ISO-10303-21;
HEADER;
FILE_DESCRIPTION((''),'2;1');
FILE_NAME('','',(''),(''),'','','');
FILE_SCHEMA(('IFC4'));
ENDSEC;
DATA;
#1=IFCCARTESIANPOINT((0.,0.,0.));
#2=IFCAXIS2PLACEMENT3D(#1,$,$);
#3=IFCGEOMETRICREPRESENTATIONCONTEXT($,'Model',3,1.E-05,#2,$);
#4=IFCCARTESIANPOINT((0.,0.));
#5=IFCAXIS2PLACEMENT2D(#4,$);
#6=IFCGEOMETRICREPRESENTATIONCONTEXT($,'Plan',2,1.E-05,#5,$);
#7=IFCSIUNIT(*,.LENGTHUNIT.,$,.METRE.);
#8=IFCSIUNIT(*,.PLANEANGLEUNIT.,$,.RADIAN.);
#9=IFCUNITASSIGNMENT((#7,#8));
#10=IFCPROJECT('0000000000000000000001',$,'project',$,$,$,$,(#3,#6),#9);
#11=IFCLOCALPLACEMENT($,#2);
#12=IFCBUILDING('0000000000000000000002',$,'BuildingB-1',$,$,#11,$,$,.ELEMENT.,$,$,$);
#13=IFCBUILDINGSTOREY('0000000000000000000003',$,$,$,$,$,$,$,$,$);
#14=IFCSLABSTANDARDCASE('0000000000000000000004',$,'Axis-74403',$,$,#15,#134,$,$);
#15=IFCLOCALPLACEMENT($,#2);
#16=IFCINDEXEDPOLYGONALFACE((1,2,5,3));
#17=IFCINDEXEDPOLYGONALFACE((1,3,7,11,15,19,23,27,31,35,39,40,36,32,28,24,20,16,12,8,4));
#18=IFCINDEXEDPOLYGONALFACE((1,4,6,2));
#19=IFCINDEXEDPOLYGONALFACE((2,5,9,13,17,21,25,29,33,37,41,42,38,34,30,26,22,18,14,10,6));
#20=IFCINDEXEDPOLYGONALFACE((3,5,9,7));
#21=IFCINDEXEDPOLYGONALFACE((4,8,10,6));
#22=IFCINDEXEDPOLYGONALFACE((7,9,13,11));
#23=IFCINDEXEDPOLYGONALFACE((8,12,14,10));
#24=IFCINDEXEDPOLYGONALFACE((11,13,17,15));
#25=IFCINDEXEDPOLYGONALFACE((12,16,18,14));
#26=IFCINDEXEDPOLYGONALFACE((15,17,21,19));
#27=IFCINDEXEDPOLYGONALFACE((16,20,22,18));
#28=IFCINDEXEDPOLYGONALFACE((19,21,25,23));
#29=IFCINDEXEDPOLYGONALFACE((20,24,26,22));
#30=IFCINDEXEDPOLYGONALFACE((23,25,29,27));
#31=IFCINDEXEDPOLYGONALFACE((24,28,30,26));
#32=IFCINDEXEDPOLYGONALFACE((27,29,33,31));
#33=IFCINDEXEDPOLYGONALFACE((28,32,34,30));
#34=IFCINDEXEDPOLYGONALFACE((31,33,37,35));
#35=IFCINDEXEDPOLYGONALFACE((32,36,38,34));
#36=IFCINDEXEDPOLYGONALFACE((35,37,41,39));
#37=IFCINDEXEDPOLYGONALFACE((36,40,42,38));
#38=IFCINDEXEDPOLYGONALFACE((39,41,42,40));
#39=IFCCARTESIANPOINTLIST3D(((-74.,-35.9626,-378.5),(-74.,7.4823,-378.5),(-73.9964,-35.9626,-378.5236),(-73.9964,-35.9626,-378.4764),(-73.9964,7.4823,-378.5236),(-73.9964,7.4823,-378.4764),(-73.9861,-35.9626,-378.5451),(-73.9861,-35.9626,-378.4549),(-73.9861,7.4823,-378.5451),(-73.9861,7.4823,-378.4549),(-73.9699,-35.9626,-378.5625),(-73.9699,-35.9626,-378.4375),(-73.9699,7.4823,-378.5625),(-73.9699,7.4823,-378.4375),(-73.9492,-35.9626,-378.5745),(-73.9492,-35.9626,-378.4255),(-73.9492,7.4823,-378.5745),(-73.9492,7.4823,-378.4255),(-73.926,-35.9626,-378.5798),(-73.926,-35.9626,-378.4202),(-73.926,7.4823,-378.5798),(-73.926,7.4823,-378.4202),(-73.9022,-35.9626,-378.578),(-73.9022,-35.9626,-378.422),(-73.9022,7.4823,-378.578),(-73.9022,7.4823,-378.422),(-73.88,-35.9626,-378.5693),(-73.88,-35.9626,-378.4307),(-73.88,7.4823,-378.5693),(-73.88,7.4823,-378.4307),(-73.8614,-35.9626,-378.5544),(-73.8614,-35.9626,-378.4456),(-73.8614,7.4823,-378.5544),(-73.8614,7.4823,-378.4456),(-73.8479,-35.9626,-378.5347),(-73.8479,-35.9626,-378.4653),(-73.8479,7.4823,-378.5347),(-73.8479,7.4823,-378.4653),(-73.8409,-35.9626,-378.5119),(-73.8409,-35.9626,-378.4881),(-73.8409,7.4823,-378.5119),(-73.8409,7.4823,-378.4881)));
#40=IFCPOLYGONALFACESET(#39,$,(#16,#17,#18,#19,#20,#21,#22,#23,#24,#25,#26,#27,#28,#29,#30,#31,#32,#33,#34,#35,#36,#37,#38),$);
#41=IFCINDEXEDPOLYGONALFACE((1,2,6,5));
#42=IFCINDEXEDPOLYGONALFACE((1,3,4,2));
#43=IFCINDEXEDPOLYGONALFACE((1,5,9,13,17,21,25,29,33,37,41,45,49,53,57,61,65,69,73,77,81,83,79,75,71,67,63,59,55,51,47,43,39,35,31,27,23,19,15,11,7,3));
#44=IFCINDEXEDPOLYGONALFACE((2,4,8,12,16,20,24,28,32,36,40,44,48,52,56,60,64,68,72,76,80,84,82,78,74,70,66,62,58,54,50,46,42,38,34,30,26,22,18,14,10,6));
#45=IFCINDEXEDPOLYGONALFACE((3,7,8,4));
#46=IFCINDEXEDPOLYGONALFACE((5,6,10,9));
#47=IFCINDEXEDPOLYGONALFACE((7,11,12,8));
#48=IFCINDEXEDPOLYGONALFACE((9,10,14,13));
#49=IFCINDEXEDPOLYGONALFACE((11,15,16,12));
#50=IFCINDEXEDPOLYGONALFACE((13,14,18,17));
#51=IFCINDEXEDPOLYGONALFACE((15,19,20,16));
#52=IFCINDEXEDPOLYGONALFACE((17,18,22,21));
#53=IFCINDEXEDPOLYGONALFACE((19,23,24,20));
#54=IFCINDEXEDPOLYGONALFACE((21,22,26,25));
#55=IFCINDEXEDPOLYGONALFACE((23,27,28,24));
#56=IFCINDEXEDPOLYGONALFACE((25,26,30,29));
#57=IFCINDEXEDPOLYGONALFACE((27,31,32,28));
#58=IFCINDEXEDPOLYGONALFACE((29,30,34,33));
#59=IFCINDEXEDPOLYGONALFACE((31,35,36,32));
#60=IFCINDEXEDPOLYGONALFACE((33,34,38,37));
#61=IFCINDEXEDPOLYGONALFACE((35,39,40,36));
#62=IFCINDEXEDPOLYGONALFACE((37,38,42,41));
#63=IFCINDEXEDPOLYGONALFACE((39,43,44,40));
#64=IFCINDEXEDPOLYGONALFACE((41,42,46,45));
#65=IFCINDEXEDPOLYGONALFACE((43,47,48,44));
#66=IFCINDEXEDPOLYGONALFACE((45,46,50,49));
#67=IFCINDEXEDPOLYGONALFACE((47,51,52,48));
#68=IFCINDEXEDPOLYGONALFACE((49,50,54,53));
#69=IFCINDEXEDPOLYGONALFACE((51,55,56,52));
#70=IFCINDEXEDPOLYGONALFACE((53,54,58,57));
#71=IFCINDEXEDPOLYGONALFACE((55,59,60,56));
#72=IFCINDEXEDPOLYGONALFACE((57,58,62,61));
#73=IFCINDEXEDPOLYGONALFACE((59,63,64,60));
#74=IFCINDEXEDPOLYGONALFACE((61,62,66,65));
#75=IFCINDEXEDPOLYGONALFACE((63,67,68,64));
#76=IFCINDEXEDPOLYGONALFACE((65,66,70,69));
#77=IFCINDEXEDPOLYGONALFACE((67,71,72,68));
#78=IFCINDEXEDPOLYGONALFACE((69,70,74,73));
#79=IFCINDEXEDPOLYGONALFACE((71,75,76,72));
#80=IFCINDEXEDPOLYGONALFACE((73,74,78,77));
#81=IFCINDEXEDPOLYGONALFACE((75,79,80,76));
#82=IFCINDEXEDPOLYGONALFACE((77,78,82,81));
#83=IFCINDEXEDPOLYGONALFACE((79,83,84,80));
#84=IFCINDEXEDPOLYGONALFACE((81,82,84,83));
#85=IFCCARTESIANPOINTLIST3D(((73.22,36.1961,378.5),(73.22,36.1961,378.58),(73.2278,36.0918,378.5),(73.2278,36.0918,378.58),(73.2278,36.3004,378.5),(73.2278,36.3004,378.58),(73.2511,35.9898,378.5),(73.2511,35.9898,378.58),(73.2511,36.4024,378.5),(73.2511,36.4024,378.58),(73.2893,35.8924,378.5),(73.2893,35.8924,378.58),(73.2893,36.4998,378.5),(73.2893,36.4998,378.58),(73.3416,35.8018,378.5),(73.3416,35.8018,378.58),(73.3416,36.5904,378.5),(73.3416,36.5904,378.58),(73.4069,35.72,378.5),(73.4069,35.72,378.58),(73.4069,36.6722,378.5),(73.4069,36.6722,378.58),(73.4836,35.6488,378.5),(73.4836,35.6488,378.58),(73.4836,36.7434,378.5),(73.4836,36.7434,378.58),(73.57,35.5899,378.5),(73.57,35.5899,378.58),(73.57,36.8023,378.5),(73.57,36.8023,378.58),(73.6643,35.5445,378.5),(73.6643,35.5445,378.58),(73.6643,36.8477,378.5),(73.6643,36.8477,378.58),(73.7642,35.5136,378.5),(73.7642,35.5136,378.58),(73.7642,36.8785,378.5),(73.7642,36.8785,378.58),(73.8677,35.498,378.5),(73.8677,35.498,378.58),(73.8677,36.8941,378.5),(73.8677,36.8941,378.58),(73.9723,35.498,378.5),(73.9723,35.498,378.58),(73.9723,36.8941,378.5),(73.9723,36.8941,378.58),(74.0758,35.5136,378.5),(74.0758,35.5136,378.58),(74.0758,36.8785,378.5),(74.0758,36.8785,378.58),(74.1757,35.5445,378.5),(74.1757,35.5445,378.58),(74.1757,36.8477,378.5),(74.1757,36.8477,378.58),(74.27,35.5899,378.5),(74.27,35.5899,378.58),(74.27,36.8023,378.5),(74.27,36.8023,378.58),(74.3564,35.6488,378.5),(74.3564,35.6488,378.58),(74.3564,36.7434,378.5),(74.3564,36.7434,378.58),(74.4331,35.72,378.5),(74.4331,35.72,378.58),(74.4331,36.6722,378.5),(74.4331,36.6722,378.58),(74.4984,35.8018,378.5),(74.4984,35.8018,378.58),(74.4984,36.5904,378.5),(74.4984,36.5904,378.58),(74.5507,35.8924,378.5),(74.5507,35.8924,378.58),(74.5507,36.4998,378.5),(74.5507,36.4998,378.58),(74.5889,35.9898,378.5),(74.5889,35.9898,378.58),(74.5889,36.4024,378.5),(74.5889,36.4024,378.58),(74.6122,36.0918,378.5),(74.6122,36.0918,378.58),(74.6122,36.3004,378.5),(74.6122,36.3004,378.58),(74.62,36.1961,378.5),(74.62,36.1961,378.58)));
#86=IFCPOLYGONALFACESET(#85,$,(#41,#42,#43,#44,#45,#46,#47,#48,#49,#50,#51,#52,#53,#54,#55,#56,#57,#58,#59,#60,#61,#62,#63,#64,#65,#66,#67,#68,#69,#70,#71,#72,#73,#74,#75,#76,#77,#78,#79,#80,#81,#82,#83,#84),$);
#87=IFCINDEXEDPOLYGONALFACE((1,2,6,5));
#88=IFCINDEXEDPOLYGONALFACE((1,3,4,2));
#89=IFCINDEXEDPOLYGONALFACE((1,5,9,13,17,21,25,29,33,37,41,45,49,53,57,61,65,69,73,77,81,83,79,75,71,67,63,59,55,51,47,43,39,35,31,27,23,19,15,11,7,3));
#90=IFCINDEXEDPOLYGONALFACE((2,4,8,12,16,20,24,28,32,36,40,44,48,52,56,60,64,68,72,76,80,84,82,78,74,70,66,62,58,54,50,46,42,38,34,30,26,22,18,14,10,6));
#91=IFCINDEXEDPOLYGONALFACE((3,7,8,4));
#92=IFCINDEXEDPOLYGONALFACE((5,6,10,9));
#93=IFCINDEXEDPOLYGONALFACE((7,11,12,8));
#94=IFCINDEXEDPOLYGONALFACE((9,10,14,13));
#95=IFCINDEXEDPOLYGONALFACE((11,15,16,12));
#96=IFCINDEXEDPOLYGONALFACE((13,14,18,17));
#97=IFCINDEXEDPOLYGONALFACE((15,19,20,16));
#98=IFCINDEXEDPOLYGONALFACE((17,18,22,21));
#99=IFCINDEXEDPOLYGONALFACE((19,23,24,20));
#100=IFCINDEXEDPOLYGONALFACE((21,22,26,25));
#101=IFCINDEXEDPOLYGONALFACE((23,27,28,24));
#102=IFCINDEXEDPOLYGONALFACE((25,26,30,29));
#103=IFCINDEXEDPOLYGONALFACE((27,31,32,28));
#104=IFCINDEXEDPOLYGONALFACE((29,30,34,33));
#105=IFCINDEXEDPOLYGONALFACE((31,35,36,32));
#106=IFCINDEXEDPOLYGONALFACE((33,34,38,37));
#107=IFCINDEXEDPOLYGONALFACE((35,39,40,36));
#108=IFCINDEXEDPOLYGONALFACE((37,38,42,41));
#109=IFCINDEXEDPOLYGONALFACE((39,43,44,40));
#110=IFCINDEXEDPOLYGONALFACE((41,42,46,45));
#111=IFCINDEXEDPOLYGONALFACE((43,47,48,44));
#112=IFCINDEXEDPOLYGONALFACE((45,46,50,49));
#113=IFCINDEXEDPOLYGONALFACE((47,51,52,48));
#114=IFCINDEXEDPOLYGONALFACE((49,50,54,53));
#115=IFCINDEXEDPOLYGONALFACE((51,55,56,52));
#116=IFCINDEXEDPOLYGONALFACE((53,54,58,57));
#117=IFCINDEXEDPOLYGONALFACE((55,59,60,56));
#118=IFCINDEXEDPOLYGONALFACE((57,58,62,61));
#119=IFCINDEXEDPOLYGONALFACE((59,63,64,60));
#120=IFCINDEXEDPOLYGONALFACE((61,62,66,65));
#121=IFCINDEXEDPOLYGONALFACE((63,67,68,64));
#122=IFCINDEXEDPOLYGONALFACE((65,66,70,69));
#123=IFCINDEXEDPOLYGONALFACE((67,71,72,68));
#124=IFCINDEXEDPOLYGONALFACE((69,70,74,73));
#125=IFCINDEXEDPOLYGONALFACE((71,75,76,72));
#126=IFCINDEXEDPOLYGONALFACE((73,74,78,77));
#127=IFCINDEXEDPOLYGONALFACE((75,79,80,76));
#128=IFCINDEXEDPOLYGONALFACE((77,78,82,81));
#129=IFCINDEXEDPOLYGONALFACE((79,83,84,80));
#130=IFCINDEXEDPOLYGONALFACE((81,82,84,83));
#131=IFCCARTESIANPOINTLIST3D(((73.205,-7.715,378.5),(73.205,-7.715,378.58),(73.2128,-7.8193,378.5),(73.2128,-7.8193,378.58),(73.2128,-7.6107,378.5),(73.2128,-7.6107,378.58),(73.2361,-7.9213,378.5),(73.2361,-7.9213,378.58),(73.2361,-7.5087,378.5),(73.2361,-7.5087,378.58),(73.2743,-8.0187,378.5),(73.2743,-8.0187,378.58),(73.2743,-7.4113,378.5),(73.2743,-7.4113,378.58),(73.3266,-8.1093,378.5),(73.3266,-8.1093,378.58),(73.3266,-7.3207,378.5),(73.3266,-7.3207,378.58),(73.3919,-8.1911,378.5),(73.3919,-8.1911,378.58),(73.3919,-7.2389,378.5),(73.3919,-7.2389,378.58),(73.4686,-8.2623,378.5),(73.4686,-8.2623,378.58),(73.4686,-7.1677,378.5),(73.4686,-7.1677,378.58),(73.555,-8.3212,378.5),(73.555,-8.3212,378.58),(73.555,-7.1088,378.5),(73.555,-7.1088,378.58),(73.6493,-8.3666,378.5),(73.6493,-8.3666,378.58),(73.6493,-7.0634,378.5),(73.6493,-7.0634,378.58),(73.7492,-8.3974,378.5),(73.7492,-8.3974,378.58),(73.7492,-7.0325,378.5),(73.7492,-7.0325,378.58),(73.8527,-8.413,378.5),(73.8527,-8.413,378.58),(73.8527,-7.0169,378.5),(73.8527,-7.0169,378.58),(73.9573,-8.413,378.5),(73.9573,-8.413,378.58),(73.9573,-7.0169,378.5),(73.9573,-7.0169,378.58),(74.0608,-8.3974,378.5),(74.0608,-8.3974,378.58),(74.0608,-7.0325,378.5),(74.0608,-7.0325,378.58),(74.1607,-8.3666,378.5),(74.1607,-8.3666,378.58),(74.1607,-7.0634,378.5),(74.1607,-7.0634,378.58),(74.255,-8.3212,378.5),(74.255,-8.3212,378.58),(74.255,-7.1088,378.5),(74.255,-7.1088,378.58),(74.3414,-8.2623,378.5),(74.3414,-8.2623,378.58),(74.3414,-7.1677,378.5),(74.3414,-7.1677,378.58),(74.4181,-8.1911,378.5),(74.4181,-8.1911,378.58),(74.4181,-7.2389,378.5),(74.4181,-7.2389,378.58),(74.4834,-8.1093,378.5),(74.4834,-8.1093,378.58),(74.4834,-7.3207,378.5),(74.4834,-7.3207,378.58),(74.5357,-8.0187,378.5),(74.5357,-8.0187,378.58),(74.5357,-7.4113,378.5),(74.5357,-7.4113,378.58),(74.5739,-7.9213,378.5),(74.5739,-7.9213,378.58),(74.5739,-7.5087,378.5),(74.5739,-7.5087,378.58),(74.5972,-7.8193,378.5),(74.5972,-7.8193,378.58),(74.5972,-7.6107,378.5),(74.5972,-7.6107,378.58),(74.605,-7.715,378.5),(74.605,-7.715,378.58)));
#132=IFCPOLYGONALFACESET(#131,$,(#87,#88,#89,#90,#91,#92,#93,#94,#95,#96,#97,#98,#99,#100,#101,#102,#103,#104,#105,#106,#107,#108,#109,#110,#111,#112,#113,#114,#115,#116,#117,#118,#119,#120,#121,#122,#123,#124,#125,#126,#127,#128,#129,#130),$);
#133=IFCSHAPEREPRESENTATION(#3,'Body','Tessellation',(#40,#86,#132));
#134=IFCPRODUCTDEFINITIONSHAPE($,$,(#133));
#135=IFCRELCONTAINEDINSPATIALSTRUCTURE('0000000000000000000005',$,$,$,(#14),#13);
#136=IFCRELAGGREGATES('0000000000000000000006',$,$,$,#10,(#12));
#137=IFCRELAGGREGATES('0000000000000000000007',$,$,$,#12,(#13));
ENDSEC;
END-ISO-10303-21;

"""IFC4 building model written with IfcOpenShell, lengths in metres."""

from ifc_helpers import new_model, entity, si_unit, frame, origin, origin_2d, place, context, project, spatial, circle, extrude, element, save


model = new_model("IFC4")

# Units and contexts
model_context = context("Model", 3, precision=1e-05, world=origin())
plan_context = context("Plan", 2, precision=1e-05, world=origin_2d())
ifc_project = project(units=[si_unit("LENGTHUNIT", "METRE"), si_unit("PLANEANGLEUNIT", "RADIAN")], contexts=[model_context, plan_context])

# Building, storey
building_placement = place(None, origin())
building = spatial("IfcBuilding", under=ifc_project, at=building_placement, Name="BuildingB-1", CompositionType="ELEMENT")
storey = spatial("IfcBuildingStorey", under=building)

# Slab
element("IfcSlabStandardCase", 1, inside=storey, Name="Axis-74403", context=model_context, shape_type="AdvancedSweptSolid", body=[
    entity("IfcSurfaceCurveSweptAreaSolid", entity("IfcCircleProfileDef", "AREA", None, None, 0.08), None, entity("IfcPolyline", [entity("IfcCartesianPoint", [73.92, 35.9626, 378.5]), entity("IfcCartesianPoint", [73.92, -7.4823, 378.5])]), None, None, entity("IfcPlane", entity("IfcAxis2Placement3D", entity("IfcCartesianPoint", [73.92, 35.9626, 378.5]), entity("IfcDirection", [0.0, 0.0, 1.0]), entity("IfcDirection", [1.0, 0.0, 0.0])))),
    extrude(circle(Radius=0.7), frame((73.92, 36.1961, 378.5)), (0.0, 0.0, 1.0), 0.08),
    extrude(circle(Radius=0.7), frame((73.905, -7.715, 378.5)), (0.0, 0.0, 1.0), 0.08),
])

save(model, "model.ifc")
